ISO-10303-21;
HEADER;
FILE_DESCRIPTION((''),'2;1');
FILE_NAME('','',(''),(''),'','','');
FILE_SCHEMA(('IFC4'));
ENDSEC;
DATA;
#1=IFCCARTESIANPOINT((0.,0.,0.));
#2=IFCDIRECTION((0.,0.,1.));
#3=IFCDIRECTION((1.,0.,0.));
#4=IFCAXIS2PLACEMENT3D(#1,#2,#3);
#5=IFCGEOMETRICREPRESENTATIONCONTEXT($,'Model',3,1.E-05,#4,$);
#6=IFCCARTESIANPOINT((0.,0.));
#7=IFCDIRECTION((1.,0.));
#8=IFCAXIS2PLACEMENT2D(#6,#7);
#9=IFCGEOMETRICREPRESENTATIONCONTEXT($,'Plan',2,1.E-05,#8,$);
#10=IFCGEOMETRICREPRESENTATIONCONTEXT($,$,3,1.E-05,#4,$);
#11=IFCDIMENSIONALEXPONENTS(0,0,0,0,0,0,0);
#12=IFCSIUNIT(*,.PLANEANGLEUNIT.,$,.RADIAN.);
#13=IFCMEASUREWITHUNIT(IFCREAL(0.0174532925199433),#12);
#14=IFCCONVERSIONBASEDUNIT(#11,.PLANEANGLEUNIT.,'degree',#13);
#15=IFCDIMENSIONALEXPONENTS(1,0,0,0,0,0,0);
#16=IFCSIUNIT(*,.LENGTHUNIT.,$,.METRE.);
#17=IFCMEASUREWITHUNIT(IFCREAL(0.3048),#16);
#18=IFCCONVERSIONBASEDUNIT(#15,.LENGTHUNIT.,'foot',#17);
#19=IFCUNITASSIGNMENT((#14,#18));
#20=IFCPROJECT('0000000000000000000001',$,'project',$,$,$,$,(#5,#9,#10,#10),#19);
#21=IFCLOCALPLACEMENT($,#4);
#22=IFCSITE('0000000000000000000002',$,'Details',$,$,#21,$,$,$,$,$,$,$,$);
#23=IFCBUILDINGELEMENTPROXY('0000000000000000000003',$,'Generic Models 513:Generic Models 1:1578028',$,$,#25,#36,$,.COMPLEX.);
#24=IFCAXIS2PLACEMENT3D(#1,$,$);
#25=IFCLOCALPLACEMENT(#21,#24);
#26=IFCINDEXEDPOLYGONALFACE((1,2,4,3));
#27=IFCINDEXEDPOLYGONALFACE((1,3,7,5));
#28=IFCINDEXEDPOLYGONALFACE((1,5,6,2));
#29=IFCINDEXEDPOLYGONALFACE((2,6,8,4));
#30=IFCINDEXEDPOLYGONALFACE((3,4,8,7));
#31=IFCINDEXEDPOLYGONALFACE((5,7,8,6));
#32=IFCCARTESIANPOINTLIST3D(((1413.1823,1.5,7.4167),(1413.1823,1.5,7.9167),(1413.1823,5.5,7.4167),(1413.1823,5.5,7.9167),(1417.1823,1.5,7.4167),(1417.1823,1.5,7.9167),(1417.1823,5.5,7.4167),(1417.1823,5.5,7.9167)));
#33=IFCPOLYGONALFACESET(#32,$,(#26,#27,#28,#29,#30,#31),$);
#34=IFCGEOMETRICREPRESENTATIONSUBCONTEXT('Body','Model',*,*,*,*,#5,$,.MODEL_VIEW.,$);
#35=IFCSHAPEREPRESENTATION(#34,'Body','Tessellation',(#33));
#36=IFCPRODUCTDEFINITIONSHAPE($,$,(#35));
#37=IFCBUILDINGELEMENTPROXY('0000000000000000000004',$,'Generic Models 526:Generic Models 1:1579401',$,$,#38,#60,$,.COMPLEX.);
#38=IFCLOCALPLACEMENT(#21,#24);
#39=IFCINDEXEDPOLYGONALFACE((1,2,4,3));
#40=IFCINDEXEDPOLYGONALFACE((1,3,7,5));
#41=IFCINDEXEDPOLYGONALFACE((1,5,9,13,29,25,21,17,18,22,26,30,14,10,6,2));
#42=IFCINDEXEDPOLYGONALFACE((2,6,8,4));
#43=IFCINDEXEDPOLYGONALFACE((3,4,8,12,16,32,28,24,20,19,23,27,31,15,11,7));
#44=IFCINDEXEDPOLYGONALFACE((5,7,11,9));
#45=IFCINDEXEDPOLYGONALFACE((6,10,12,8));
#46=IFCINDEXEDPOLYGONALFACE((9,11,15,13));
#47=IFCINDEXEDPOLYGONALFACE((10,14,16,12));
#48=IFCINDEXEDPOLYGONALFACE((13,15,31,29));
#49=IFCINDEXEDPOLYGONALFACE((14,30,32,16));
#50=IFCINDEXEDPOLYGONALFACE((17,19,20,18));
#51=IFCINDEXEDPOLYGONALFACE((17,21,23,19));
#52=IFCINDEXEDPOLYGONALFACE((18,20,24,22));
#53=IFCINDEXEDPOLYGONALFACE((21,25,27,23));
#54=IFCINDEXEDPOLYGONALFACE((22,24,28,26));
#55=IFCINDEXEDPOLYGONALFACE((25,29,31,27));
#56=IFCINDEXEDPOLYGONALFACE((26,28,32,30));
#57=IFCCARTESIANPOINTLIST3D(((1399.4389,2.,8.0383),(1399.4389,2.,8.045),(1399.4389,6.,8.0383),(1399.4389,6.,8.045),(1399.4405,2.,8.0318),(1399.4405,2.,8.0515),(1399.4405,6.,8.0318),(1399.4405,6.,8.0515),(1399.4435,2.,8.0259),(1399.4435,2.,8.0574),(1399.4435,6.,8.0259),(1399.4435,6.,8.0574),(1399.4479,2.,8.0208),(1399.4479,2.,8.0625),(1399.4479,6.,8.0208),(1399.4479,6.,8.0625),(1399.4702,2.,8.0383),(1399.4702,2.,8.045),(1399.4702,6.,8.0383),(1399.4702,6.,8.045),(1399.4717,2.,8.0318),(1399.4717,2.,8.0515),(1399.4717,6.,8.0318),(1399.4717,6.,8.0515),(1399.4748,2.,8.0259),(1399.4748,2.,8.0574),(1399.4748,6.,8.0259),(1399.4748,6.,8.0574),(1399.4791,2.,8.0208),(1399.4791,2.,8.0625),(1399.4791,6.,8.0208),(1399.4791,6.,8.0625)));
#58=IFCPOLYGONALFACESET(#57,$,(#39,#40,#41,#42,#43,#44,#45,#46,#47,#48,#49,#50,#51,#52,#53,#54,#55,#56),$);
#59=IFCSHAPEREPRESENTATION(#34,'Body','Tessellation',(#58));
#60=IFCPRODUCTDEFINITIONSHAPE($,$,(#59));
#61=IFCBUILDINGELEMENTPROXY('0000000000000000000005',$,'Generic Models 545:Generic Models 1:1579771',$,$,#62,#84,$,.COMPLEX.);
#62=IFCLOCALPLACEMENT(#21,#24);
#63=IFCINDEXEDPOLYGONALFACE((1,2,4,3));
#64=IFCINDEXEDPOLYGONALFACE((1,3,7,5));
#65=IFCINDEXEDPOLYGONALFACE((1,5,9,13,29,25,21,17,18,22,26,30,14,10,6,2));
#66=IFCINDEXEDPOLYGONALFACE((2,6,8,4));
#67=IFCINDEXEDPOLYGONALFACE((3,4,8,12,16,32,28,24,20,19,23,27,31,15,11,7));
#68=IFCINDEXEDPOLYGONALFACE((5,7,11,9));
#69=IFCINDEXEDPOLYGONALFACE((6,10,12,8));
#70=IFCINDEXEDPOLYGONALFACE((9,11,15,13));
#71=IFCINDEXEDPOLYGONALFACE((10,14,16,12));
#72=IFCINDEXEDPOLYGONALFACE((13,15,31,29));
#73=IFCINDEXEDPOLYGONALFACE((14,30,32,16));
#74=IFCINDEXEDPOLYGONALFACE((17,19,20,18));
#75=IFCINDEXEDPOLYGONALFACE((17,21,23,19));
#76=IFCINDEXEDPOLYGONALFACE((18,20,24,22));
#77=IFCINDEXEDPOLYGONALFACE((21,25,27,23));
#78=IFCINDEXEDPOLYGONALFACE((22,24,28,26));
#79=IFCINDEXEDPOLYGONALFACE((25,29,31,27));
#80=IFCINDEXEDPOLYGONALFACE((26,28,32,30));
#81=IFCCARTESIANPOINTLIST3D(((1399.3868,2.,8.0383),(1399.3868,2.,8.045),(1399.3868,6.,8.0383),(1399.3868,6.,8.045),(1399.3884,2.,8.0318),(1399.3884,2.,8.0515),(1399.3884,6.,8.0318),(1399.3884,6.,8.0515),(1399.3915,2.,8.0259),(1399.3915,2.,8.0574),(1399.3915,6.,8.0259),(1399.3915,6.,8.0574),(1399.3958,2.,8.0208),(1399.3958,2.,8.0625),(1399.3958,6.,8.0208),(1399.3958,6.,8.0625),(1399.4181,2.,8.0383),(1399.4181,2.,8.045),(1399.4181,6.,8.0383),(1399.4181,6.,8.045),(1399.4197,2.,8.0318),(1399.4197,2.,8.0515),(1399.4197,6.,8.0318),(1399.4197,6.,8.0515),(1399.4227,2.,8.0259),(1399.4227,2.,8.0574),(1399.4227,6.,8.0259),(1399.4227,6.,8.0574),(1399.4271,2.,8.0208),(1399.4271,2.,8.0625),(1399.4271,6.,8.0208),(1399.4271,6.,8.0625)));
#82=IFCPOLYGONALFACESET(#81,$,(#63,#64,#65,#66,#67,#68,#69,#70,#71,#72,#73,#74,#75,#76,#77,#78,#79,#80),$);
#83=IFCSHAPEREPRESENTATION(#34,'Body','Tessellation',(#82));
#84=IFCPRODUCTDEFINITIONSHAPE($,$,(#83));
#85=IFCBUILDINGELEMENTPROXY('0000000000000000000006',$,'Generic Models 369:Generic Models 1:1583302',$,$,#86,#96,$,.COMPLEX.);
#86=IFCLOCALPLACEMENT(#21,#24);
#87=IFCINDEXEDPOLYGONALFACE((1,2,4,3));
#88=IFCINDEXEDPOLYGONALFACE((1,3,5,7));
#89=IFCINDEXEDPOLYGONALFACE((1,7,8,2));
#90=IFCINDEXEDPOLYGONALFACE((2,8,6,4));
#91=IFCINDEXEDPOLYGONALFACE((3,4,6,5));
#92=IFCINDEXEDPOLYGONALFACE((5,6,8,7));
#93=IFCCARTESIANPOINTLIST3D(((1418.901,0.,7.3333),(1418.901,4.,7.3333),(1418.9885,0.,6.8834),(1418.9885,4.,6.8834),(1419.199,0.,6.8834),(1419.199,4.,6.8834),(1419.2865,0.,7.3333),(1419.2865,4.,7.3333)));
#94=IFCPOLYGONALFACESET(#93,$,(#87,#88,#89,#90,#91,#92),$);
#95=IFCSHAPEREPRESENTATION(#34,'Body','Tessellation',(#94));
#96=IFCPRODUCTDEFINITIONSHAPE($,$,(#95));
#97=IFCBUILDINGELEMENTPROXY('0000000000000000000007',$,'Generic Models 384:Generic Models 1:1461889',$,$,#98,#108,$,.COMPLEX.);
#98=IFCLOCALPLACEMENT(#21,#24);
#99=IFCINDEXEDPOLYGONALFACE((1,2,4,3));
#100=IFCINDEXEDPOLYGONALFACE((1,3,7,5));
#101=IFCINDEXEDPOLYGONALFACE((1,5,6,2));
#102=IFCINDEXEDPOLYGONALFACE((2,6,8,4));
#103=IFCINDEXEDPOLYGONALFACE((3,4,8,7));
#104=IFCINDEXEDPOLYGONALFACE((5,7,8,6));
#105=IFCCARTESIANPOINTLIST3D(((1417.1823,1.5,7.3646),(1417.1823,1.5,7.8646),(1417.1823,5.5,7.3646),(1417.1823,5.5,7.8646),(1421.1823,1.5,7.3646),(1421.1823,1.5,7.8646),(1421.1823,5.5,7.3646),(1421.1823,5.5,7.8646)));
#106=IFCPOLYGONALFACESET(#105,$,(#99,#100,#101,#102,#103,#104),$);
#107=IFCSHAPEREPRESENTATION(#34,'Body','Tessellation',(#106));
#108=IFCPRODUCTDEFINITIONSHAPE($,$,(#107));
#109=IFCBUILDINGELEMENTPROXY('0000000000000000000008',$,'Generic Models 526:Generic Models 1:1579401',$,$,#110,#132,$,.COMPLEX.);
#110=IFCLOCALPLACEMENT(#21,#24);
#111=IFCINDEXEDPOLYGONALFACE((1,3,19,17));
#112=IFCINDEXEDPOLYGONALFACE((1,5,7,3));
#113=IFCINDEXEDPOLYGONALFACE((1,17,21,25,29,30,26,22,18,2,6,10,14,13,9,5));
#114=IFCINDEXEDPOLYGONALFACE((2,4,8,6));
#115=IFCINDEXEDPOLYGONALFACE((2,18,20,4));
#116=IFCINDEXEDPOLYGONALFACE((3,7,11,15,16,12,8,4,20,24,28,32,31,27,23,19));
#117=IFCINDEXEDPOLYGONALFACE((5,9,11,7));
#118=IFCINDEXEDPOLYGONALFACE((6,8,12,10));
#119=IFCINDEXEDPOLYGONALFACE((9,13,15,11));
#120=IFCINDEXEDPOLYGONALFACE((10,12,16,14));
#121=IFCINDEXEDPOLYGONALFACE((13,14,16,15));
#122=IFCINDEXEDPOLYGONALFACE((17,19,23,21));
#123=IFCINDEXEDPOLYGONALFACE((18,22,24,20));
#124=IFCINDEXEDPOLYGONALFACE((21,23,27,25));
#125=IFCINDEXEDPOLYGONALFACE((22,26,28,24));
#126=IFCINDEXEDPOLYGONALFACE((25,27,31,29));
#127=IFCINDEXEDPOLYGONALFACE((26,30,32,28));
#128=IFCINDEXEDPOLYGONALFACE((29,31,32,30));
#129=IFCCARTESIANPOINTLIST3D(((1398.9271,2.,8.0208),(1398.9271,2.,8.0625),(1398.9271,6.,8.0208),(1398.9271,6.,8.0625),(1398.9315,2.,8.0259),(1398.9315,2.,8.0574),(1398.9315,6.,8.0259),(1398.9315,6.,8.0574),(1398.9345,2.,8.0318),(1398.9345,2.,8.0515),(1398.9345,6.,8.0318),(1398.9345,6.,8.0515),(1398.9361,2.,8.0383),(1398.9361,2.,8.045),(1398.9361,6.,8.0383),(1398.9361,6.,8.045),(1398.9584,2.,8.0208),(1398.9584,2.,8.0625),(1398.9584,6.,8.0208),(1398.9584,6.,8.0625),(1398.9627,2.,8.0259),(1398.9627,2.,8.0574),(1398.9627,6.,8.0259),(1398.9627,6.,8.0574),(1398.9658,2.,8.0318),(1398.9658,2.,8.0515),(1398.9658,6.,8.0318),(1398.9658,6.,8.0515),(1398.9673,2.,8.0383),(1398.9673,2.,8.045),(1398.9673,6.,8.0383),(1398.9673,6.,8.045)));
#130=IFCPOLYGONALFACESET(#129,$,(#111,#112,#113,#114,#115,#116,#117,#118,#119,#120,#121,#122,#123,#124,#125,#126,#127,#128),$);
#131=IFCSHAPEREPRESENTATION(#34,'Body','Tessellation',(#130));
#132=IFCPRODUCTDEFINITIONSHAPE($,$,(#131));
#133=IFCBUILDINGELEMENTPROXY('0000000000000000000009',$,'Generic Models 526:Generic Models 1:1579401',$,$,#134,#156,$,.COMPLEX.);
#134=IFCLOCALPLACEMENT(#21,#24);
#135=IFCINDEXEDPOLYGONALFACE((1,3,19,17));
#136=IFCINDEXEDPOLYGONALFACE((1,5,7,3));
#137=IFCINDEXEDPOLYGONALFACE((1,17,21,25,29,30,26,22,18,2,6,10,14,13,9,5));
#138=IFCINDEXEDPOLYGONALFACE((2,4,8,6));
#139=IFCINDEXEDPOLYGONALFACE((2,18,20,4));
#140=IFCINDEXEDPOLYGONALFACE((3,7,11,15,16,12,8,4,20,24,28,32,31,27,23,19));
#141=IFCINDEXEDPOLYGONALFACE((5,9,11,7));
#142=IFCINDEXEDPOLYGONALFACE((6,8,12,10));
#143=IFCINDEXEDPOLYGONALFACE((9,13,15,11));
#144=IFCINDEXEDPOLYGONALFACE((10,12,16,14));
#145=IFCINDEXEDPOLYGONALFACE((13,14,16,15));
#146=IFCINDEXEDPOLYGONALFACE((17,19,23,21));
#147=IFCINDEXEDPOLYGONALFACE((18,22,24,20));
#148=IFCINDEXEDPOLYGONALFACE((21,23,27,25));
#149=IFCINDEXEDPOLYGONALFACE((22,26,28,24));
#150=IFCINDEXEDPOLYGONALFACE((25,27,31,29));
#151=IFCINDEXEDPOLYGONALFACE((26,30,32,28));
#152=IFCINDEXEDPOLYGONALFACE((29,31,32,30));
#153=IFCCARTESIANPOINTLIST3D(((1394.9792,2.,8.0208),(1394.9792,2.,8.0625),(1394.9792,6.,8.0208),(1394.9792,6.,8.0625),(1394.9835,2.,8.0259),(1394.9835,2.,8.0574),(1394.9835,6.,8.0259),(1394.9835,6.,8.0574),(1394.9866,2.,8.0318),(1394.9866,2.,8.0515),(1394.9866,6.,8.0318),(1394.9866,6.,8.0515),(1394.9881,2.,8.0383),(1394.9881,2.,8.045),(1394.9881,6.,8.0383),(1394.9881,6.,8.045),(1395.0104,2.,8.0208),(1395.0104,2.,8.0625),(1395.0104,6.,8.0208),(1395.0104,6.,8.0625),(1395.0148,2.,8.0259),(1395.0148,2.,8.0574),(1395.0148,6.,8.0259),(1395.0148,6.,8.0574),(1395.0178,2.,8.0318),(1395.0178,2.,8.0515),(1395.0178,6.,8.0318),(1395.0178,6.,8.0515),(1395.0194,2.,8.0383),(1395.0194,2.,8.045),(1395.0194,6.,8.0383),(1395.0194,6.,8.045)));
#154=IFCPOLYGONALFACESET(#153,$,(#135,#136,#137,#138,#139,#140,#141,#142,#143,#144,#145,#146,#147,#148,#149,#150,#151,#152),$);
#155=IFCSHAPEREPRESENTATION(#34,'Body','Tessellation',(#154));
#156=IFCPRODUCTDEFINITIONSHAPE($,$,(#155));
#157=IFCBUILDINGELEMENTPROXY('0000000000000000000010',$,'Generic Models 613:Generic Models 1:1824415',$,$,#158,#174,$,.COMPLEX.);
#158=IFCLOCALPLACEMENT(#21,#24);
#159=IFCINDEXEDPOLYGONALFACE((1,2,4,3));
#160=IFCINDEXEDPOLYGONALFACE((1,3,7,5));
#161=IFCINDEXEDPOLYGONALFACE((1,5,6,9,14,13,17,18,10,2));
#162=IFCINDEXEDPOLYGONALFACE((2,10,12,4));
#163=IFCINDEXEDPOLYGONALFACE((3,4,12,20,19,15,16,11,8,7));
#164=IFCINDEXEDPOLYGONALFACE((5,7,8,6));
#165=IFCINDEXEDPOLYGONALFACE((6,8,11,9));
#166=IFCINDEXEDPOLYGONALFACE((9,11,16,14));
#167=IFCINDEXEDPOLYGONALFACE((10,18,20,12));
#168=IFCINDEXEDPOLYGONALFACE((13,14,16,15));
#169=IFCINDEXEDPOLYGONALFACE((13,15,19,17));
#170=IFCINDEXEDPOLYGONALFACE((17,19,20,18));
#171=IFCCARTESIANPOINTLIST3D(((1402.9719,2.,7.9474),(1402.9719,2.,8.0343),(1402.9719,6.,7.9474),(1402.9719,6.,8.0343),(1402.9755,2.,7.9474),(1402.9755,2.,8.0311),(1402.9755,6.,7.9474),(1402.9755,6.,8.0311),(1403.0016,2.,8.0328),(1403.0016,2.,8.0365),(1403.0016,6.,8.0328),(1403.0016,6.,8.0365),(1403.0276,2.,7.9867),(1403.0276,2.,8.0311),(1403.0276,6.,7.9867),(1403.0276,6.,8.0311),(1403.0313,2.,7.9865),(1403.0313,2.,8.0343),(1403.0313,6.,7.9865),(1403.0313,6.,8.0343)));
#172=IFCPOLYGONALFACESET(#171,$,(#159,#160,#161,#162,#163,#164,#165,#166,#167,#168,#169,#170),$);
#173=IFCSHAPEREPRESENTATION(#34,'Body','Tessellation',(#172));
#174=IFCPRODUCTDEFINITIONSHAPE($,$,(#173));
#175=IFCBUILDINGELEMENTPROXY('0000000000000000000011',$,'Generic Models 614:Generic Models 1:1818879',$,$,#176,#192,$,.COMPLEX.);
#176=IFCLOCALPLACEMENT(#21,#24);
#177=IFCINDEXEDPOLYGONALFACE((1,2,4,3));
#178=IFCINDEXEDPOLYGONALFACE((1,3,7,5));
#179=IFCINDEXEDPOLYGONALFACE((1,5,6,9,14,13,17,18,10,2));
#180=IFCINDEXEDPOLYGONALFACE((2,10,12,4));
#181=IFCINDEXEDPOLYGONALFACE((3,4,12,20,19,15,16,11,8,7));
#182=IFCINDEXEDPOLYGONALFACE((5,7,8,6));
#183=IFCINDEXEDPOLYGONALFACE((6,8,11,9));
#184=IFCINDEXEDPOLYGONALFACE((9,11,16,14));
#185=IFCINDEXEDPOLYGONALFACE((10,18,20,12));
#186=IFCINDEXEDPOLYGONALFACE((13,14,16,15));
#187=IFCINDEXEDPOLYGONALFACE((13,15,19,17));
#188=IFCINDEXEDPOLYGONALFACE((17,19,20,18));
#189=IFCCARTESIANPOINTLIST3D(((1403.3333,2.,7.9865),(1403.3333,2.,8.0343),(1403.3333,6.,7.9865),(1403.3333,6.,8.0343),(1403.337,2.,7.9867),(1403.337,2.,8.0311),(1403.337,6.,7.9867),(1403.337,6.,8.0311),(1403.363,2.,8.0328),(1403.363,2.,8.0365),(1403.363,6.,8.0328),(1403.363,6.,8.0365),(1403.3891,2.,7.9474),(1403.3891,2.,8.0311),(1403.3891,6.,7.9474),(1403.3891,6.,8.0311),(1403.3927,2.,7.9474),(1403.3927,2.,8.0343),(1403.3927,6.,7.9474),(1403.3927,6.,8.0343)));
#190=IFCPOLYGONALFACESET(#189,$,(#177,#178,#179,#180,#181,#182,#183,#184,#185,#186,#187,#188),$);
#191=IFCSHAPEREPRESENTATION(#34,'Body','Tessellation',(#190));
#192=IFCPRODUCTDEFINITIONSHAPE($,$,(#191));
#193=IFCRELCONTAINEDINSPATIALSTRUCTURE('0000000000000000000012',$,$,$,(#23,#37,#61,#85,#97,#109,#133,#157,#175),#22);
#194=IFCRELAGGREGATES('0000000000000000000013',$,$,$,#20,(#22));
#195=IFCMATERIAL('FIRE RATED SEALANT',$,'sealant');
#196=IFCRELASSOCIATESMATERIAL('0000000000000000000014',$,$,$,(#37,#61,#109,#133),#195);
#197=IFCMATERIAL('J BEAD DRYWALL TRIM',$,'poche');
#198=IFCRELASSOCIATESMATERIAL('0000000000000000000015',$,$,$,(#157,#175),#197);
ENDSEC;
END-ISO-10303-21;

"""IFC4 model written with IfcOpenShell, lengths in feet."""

from ifc_helpers import new_model, entity, si_unit, converted_unit, frame, origin_with_axes, origin_2d_with_axis, place, context, subcontext, project, spatial, polyline, line, indexed_curve, outline, extrude, material, element, save


model = new_model("IFC4")

# Units and contexts
model_context = context("Model", 3, precision=1e-05, world=origin_with_axes())
plan_context = context("Plan", 2, precision=1e-05, world=origin_2d_with_axis())
context_of_model = context(None, 3, precision=1e-05, world=origin_with_axes())
body_context = subcontext(model_context, "Body", "Model", "MODEL_VIEW")
ifc_project = project(units=[converted_unit("PLANEANGLEUNIT", "degree", entity("IfcReal", 0.0174532925199433), si_unit("PLANEANGLEUNIT", "RADIAN"), dimensions=[0, 0, 0, 0, 0, 0, 0]), converted_unit("LENGTHUNIT", "foot", entity("IfcReal", 0.3048), si_unit("LENGTHUNIT", "METRE"), dimensions=[1, 0, 0, 0, 0, 0, 0])], contexts=[model_context, plan_context, context_of_model, context_of_model])

# Site
site_placement = place(None, origin_with_axes())
site = spatial("IfcSite", under=ifc_project, at=site_placement, Name="Details")

# Building element proxies
proxy_1_placement = place(site_placement, frame((1413.1823, 5.5, 7.4167), z_axis=(0.0, -1.0, 0.0), x_axis=(0.0, 0.0, 1.0)))
element("IfcBuildingElementProxy", 1, at=proxy_1_placement, inside=site, Name="Generic Models 513:Generic Models 1:1578028", PredefinedType="COMPLEX", context=body_context, shape_type="SweptSolid", body=[
    extrude(outline(polyline([(-0.25, -2.0), (0.25, -2.0), (0.25, 2.0), (-0.25, 2.0), (-0.25, -2.0)])), frame((0.25, -2.0, 0.0), z_axis=(0.0, 0.0, -1.0), x_axis=(1.0, 0.0, 0.0)), (0.0, 0.0, -1.0), 4.0),
])
ifc_material_1 = material(Name="FIRE RATED SEALANT", Category="sealant")
proxy_2_placement = place(site_placement, frame((1399.4389, 6.0, 8.0208), z_axis=(0.0, -1.0, 0.0), x_axis=(0.0, 0.0, 1.0)))
element("IfcBuildingElementProxy", 2, at=proxy_2_placement, inside=site, material=ifc_material_1, Name="Generic Models 526:Generic Models 1:1579401", PredefinedType="COMPLEX", context=body_context, shape_type="SweptSolid", body=[
    extrude(outline(polyline([(0.0294, 0.0), (0.0074, 0.0221), (0.0007, 0.0216), (-0.0057, 0.0196), (-0.0114, 0.0161), (-0.0161, 0.0114), (-0.0196, 0.0057), (-0.0216, -0.0007), (-0.0221, -0.0073), (0.0, -0.0294), (0.0005, -0.0228), (0.0025, -0.0164), (0.006, -0.0107), (0.0107, -0.006), (0.0164, -0.0025), (0.0228, -0.0005), (0.0294, 0.0)])), frame((0.0208, -0.0194, 0.0), z_axis=(0.0, 0.0, -1.0), x_axis=(-0.707667, -0.706546, 0.0)), (0.0, 0.0, -1.0), 4.0),
])
proxy_3_placement = place(site_placement, frame((1399.3868, 6.0, 8.0208), z_axis=(0.0, -1.0, 0.0), x_axis=(0.0, 0.0, 1.0)))
element("IfcBuildingElementProxy", 3, at=proxy_3_placement, inside=site, material=ifc_material_1, Name="Generic Models 545:Generic Models 1:1579771", PredefinedType="COMPLEX", context=body_context, shape_type="SweptSolid", body=[
    extrude(outline(polyline([(0.0166, 0.0), (0.0115, 0.0043), (0.0076, 0.0097), (0.005, 0.0159), (0.0039, 0.0224), (0.0045, 0.0291), (-0.0207, 0.0106), (-0.0213, 0.004), (-0.0202, -0.0026), (-0.0176, -0.0088), (-0.0137, -0.0142), (-0.0086, -0.0185), (-0.0026, -0.0215), (0.0039, -0.023), (0.0291, -0.0045), (0.0226, -0.003), (0.0166, 0.0)])), frame((0.0208, -0.0194, 0.0), z_axis=(0.0, 0.0, -1.0), x_axis=(0.591192, -0.806531, 0.0)), (0.0, 0.0, -1.0), 4.0),
])
proxy_4_placement = place(site_placement, frame((1419.2865, 0.0, 6.8834), z_axis=(0.0, 1.0, 0.0), x_axis=(0.0, 0.0, 1.0)))
element("IfcBuildingElementProxy", 4, at=proxy_4_placement, inside=site, Name="Generic Models 369:Generic Models 1:1583302", PredefinedType="COMPLEX", context=body_context, shape_type="SweptSolid", body=[
    extrude(outline(indexed_curve([(-0.1053, 0.225), (0.1053, 0.225), (0.1927, -0.225), (-0.1927, -0.225)], segments=[line(4, 1), line(1, 2), line(2, 3), line(3, 4)], self_intersect=False)), frame((0.225, -0.1927, 4.0), z_axis=(0.0, 0.0, -1.0), x_axis=(0.0, -1.0, 0.0)), (0.0, 0.0, 1.0), 4.0),
])
proxy_5_placement = place(site_placement, frame((1417.1823, 5.5, 7.3646), z_axis=(0.0, -1.0, 0.0), x_axis=(0.0, 0.0, 1.0)))
element("IfcBuildingElementProxy", 5, at=proxy_5_placement, inside=site, Name="Generic Models 384:Generic Models 1:1461889", PredefinedType="COMPLEX", context=body_context, shape_type="SweptSolid", body=[
    extrude(outline(polyline([(-0.25, -2.0), (0.25, -2.0), (0.25, 2.0), (-0.25, 2.0), (-0.25, -2.0)])), frame((0.25, -2.0, 0.0), z_axis=(0.0, 0.0, -1.0), x_axis=(1.0, 0.0, 0.0)), (0.0, 0.0, -1.0), 4.0),
])
for number, where, z_axis, x_axis, name in (
    (6, (1398.9271, 6.0, 8.0208), (0.0, -1.0, 0.0), (0.0, 0.0, 1.0), "Generic Models 526:Generic Models 1:1579401"),
    (7, (1394.9791, 6.0, 8.0208), (0.0, -1.0, 0.0), (0.0, 0.0, 1.0), "Generic Models 526:Generic Models 1:1579401"),
):
    element("IfcBuildingElementProxy", number, at=place(site_placement, frame(where, z_axis=z_axis, x_axis=x_axis)), inside=site, material=ifc_material_1, Name=name, PredefinedType="COMPLEX", context=body_context, shape_type="SweptSolid", body=[
        extrude(outline(polyline([(0.0216, 0.0), (0.0223, 0.0066), (0.001, 0.0294), (0.0002, 0.0228), (-0.002, 0.0165), (-0.0057, 0.0109), (-0.0105, 0.0064), (-0.0163, 0.0031), (-0.0228, 0.0012), (-0.0294, 0.0009), (-0.008, -0.0219), (-0.0014, -0.0216), (0.005, -0.0197), (0.0108, -0.0164), (0.0157, -0.0119), (0.0194, -0.0063), (0.0216, 0.0)])), frame((0.0208, -0.0208, 0.0), z_axis=(0.0, 0.0, -1.0), x_axis=(-0.729168, -0.684334, 0.0)), (0.0, 0.0, -1.0), 4.0),
    ])
ifc_material_2 = material(Name="J BEAD DRYWALL TRIM", Category="poche")
proxy_6_placement = place(site_placement, frame((1402.9719, 6.0, 7.9474), z_axis=(0.0, -1.0, 0.0), x_axis=(0.0, 0.0, 1.0)))
element("IfcBuildingElementProxy", 8, at=proxy_6_placement, inside=site, material=ifc_material_2, Name="Generic Models 613:Generic Models 1:1824415", PredefinedType="COMPLEX", context=body_context, shape_type="SweptSolid", body=[
    extrude(outline(indexed_curve([(-0.0243, 0.026), (0.0594, 0.026), (0.0594, 0.0297), (-0.0275, 0.0297), (-0.0296, 0.0), (-0.0275, -0.0297), (0.0203, -0.0297), (0.0201, -0.026), (-0.0243, -0.026), (-0.026, 0.0)], segments=[line(5, 4), line(4, 3), line(3, 2), line(2, 1), line(1, 10), line(10, 9), line(9, 8), line(8, 7), line(7, 6), line(6, 5)], self_intersect=False)), frame((0.0594, -0.0297, 0.0), z_axis=(0.0, 0.0, -1.0), x_axis=(-1.0, 0.0, 0.0)), (0.0, 0.0, -1.0), 4.0),
])
proxy_7_placement = place(site_placement, frame((1403.3333, 6.0, 7.9474), z_axis=(0.0, -1.0, 0.0), x_axis=(0.0, 0.0, 1.0)))
element("IfcBuildingElementProxy", 9, at=proxy_7_placement, inside=site, material=ifc_material_2, Name="Generic Models 614:Generic Models 1:1818879", PredefinedType="COMPLEX", context=body_context, shape_type="SweptSolid", body=[
    extrude(outline(indexed_curve([(-0.0203, -0.0297), (0.0275, -0.0297), (0.0296, 0.0), (0.0275, 0.0297), (-0.0594, 0.0297), (-0.0594, 0.026), (0.0243, 0.026), (0.026, 0.0), (0.0243, -0.026), (-0.0201, -0.026)], segments=[line(3, 2), line(2, 1), line(1, 10), line(10, 9), line(9, 8), line(8, 7), line(7, 6), line(6, 5), line(5, 4), line(4, 3)], self_intersect=False)), frame((0.0594, -0.0297, 0.0), z_axis=(0.0, 0.0, -1.0), x_axis=(1.0, 0.0, 0.0)), (0.0, 0.0, -1.0), 4.0),
])

save(model, "model.ifc")
